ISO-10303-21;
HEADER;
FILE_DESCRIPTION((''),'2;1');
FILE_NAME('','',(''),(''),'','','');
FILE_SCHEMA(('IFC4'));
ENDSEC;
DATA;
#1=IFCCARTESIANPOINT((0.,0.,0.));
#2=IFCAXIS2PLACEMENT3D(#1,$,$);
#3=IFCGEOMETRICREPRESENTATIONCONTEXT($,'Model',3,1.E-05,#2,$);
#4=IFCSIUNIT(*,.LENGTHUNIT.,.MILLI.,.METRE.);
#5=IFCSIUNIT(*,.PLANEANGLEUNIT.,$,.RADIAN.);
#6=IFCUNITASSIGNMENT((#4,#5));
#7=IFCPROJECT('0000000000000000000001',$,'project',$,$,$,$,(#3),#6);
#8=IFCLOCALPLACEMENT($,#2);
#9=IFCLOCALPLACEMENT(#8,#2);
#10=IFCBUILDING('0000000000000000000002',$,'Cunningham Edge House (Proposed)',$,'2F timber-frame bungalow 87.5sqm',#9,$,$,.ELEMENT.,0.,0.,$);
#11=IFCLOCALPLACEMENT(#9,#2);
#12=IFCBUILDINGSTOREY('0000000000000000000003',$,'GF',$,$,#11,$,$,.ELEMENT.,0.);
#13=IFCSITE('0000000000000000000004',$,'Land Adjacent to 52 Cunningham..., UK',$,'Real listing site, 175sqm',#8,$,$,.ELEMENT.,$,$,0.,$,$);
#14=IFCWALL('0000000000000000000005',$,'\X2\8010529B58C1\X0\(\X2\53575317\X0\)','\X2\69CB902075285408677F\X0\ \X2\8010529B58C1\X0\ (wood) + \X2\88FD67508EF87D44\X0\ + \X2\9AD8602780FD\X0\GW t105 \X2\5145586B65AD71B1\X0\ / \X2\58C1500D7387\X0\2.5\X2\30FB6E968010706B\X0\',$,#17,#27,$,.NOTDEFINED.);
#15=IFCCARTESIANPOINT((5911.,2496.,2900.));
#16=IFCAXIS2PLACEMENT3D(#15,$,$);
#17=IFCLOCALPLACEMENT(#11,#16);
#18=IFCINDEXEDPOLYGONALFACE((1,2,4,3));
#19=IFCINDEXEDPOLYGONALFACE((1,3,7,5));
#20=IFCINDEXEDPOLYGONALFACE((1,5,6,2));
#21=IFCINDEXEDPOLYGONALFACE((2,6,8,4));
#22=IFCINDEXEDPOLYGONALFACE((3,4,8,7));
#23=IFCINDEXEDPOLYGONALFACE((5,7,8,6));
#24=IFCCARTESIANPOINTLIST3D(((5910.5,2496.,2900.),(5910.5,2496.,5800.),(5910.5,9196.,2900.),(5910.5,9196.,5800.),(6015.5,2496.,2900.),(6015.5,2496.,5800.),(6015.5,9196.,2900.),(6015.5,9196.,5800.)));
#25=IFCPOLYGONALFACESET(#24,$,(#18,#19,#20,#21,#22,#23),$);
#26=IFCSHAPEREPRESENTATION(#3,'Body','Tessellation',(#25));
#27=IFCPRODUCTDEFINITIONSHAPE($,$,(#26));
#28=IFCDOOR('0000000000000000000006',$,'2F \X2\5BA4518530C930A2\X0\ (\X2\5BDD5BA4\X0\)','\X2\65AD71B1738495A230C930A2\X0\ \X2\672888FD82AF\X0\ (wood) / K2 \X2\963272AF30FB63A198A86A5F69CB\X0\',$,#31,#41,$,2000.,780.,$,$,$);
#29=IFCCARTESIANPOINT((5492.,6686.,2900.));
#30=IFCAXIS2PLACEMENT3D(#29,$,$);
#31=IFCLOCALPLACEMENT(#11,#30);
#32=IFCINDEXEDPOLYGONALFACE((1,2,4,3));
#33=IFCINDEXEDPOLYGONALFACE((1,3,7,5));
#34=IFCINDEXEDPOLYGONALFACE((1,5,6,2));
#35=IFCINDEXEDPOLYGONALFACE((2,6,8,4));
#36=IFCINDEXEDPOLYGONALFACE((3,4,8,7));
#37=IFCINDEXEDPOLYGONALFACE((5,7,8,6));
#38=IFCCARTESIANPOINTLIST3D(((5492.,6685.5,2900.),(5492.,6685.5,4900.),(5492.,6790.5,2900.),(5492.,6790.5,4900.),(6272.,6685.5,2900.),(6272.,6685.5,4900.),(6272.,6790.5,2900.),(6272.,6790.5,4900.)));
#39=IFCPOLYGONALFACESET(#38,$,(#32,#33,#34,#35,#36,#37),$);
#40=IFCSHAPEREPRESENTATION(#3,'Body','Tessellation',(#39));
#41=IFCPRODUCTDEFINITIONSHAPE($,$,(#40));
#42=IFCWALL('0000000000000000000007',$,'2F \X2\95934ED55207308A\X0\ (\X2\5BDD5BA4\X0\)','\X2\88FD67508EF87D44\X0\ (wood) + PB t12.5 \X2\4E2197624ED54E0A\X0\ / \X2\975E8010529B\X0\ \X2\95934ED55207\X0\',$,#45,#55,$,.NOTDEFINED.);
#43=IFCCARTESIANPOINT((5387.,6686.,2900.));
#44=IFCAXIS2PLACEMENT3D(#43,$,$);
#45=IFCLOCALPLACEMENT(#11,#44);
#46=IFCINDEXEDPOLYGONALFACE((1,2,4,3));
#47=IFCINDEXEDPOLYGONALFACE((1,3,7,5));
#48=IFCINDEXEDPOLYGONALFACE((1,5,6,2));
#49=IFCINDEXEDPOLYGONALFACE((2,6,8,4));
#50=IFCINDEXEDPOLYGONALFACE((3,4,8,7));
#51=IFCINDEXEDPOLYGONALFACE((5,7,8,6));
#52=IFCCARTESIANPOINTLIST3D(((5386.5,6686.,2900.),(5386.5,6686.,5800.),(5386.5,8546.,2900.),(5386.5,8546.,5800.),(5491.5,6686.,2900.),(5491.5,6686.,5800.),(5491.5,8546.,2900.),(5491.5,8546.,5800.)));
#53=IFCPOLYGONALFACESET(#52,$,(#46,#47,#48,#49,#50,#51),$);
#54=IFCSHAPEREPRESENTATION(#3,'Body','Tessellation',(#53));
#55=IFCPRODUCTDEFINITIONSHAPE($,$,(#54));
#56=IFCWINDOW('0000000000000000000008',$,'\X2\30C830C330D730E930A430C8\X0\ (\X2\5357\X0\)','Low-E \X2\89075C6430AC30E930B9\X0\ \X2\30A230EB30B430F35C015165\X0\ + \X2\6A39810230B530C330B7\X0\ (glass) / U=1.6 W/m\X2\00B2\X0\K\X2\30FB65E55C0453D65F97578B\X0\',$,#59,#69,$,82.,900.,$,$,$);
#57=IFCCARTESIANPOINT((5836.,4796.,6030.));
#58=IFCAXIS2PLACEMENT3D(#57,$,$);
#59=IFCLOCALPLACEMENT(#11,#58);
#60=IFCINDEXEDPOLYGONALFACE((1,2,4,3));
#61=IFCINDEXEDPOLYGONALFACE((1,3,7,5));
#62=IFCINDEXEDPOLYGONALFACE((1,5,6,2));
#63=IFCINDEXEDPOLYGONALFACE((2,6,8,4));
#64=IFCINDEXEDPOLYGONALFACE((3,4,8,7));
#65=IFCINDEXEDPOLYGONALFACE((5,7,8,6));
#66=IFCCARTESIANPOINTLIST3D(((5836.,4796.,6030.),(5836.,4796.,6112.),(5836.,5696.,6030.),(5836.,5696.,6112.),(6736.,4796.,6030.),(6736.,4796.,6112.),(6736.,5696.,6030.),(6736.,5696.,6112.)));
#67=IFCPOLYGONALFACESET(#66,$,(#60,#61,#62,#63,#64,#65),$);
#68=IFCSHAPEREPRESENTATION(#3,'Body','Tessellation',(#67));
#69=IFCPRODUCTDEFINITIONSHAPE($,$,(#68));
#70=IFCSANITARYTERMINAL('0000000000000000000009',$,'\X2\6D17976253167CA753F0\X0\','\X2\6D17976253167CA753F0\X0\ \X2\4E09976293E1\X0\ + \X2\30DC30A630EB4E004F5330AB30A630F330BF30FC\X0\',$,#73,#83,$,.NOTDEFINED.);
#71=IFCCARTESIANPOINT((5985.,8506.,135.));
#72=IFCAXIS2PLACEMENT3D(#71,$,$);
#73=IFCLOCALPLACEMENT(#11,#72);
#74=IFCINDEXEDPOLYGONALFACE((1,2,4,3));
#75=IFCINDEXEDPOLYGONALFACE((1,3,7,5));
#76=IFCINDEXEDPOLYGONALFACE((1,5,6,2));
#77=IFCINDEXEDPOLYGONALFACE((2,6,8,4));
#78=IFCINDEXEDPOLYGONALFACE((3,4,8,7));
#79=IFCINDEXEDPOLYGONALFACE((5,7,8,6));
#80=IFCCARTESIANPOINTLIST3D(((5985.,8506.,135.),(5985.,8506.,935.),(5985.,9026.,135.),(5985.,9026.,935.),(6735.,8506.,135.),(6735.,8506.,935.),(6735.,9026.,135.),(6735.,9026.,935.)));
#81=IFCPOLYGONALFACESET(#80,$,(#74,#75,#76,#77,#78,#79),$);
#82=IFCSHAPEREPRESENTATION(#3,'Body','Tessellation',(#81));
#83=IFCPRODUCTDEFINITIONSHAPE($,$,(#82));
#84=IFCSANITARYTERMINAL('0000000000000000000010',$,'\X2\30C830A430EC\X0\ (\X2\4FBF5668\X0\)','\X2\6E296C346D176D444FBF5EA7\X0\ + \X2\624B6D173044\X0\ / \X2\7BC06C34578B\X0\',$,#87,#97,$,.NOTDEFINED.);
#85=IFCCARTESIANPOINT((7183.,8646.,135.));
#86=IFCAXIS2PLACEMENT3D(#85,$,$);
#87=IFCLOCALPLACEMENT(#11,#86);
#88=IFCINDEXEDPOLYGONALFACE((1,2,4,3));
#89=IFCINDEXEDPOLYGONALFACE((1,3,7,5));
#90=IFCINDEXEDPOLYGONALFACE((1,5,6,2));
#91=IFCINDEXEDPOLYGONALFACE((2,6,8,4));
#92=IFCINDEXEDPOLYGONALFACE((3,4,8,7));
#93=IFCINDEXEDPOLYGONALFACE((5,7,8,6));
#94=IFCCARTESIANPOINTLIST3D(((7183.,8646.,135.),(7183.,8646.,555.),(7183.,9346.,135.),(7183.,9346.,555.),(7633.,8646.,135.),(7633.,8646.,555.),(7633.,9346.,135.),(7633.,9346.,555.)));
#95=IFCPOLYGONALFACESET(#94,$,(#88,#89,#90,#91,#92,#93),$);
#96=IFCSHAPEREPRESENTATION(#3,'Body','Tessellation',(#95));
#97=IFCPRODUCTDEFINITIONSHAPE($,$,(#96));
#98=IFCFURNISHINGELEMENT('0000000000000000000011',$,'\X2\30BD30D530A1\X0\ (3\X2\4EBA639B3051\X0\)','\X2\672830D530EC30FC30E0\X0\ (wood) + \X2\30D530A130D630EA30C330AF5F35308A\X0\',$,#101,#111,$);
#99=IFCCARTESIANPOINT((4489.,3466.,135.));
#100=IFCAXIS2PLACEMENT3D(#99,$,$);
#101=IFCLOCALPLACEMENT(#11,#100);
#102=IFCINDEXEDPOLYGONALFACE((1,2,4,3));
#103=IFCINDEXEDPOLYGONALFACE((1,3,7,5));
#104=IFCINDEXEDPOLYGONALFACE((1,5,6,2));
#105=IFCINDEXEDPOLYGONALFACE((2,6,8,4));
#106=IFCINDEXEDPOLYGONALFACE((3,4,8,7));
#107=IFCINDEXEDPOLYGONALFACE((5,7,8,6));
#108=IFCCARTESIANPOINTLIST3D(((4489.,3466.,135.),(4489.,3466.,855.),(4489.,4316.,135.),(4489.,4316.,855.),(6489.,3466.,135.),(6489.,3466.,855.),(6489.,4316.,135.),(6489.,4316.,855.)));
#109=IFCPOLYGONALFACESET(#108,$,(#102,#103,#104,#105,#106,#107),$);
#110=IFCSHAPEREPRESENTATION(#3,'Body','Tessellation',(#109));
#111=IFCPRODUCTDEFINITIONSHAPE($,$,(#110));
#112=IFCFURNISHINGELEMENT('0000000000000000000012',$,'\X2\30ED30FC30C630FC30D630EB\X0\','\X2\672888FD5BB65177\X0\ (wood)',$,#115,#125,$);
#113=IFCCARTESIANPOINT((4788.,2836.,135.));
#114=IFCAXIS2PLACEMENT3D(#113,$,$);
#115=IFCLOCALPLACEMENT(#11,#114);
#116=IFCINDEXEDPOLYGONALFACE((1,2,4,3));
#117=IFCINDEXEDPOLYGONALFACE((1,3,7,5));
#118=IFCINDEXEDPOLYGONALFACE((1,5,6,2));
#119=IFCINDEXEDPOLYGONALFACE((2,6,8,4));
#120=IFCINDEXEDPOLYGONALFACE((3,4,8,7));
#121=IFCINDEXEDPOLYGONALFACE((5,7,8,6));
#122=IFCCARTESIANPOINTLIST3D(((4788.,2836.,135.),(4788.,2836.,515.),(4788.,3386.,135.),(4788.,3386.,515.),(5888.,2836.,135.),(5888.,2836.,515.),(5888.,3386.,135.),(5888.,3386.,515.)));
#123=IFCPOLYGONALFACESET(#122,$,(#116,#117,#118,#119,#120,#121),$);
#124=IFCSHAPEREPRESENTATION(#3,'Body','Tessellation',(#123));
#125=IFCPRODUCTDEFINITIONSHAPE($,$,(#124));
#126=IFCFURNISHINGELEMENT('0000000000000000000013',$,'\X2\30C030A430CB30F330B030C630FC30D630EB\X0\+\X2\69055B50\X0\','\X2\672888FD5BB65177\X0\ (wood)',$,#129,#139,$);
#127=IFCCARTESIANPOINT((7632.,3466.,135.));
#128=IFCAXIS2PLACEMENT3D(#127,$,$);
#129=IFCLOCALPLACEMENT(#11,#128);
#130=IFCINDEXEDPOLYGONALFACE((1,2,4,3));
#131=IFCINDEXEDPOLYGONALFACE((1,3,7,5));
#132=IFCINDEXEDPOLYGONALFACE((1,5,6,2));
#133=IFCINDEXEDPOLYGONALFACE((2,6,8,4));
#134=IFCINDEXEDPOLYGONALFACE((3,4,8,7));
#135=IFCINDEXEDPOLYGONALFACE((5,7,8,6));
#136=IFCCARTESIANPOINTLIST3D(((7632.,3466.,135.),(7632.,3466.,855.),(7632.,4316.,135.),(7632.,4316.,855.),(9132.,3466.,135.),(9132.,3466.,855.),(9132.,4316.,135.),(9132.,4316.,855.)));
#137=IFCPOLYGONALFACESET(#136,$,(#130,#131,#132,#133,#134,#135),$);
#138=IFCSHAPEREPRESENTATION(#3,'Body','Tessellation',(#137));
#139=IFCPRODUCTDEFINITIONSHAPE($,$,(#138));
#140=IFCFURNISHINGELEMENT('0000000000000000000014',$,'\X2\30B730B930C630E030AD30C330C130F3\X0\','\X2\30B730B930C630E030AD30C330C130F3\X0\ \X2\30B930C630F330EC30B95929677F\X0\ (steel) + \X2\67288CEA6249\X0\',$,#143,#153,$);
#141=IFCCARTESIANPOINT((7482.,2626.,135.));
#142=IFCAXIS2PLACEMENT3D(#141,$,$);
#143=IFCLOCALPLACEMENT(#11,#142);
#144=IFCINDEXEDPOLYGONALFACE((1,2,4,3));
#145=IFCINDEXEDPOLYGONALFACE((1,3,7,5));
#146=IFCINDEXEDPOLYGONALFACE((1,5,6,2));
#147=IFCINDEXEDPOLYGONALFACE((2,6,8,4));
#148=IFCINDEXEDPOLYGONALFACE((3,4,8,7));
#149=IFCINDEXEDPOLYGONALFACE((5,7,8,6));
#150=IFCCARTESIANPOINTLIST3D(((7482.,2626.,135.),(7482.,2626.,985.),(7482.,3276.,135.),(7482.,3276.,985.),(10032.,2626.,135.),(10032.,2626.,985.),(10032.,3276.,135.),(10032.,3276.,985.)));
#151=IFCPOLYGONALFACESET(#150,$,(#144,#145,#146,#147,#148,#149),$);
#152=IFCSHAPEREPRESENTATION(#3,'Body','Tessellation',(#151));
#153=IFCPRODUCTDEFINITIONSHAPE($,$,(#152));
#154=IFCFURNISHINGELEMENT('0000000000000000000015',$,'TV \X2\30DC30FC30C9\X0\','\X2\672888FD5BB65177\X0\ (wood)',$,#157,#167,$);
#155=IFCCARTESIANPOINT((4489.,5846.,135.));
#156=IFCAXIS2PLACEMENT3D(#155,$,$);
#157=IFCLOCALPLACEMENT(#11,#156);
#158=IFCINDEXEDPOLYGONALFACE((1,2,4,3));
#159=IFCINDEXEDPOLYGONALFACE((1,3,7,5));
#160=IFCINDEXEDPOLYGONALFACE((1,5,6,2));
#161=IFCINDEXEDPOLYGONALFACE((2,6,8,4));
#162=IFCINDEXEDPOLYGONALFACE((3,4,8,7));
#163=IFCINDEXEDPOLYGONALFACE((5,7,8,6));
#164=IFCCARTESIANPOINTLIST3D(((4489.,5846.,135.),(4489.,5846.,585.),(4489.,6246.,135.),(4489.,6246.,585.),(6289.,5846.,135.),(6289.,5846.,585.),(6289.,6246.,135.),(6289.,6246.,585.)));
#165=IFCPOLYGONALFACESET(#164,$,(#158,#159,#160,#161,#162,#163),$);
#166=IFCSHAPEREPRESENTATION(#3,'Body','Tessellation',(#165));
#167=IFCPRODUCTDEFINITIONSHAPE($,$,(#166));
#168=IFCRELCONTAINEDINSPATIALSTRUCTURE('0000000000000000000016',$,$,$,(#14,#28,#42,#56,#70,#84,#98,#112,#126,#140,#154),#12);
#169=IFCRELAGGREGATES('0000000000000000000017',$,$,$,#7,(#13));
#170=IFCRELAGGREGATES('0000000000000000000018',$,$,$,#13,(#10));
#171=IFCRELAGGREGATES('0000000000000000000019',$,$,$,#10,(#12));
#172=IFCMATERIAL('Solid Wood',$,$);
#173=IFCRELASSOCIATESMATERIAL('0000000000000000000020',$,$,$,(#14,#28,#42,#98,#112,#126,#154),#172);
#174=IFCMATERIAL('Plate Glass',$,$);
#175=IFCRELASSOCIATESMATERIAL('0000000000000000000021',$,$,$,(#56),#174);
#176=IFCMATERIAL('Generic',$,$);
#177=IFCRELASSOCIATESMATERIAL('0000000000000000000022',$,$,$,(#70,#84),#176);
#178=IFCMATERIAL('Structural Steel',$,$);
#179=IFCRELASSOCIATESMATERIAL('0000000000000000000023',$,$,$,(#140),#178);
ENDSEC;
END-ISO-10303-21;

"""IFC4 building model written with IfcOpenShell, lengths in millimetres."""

from ifc_helpers import new_model, si_unit, frame, frame_2d, origin, place, context, project, spatial, rectangle, extrude, material, element, fill, save


model = new_model("IFC4")

# Units and contexts
model_context = context("Model", 3, precision=1e-05, world=origin())
ifc_project = project(units=[si_unit("LENGTHUNIT", "METRE", prefix="MILLI"), si_unit("PLANEANGLEUNIT", "RADIAN")], contexts=[model_context])

# Site, building, storey
site_placement = place(None, origin())
site = spatial("IfcSite", under=ifc_project, at=site_placement, Name="Land Adjacent to 52 Cunningham..., UK", ObjectType="Real listing site, 175sqm", CompositionType="ELEMENT", RefElevation=0.0)
building_placement = place(site_placement, origin())
building = spatial("IfcBuilding", under=site, at=building_placement, Name="Cunningham Edge House (Proposed)", ObjectType="2F timber-frame bungalow 87.5sqm", CompositionType="ELEMENT", ElevationOfRefHeight=0.0, ElevationOfTerrain=0.0)
storey_placement = place(building_placement, origin())
storey = spatial("IfcBuildingStorey", under=building, at=storey_placement, Name="GF", CompositionType="ELEMENT", Elevation=0.0)

# Shared definitions
ifc_material_1 = material(Name="Solid Wood")

# Wall, opening, door
wall_1_placement = place(storey_placement, frame((5911.0, 2496.0, 2900.0)))
wall_1 = element("IfcWall", 1, at=wall_1_placement, inside=storey, material=ifc_material_1, Name="耐力壁(南北)", Description="構造用合板 耐力壁 (wood) + 製材軸組 + 高性能GW t105 充填断熱 / 壁倍率2.5・準耐火", PredefinedType="NOTDEFINED", context=model_context, shape_type="SweptSolid", body=[
    extrude(rectangle(XDim=105.0, YDim=6700.0, at=frame_2d((52.0, 3350.0))), frame((5911.0, 2496.0, 2900.0)), (0.0, 0.0, 1.0), 2900.0),
])
opening_1_placement = place(storey_placement, frame((5492.0, 6686.0, 2900.0)))
opening_1 = element("IfcOpeningElement", 2, at=opening_1_placement, cuts=wall_1, PredefinedType="NOTDEFINED", context=model_context, shape_type="SweptSolid", body=[
    extrude(rectangle(XDim=780.0, YDim=105.0, at=frame_2d((390.0, 52.0))), frame((5492.0, 6686.0, 2900.0)), (0.0, 0.0, 1.0), 2000.0),
])
door_1_placement = place(storey_placement, frame((5492.0, 6686.0, 2900.0)))
door_1 = element("IfcDoor", 3, at=door_1_placement, inside=storey, material=ifc_material_1, Name="2F 室内ドア (寝室)", Description="断熱玄関ドア 木製芯 (wood) / K2 防犯・採風機構", OverallHeight=2000.0, OverallWidth=780.0, context=model_context, shape_type="SweptSolid", body=[
    extrude(rectangle(XDim=780.0, YDim=105.0, at=frame_2d((390.0, 52.0))), frame((5492.0, 6686.0, 2900.0)), (0.0, 0.0, 1.0), 2000.0),
])
fill(opening_1, door_1)

# Wall
wall_2_placement = place(storey_placement, frame((5387.0, 6686.0, 2900.0)))
element("IfcWall", 4, at=wall_2_placement, inside=storey, material=ifc_material_1, Name="2F 間仕切り (寝室)", Description="製材軸組 (wood) + PB t12.5 両面仕上 / 非耐力 間仕切", PredefinedType="NOTDEFINED", context=model_context, shape_type="SweptSolid", body=[
    extrude(rectangle(XDim=105.0, YDim=1860.0, at=frame_2d((52.0, 930.0))), frame((5387.0, 6686.0, 2900.0)), (0.0, 0.0, 1.0), 2900.0),
])

# Window
ifc_material_2 = material(Name="Plate Glass")
window_placement = place(storey_placement, frame((5836.0, 4796.0, 6030.0)))
element("IfcWindow", 5, at=window_placement, inside=storey, material=ifc_material_2, Name="トップライト (南)", Description="Low-E 複層ガラス アルゴン封入 + 樹脂サッシ (glass) / U=1.6 W/m²K・日射取得型", OverallHeight=82.0, OverallWidth=900.0, context=model_context, shape_type="SweptSolid", body=[
    extrude(rectangle(XDim=900.0, YDim=900.0, at=frame_2d((450.0, 450.0))), frame((5836.0, 4796.0, 6030.0)), (0.0, 0.0, 1.0), 82.0),
])

# Sanitary terminals
ifc_material_3 = material(Name="Generic")
sanitary_terminal_1_placement = place(storey_placement, frame((5985.0, 8506.0, 135.0)))
element("IfcSanitaryTerminal", 6, at=sanitary_terminal_1_placement, inside=storey, material=ifc_material_3, Name="洗面化粧台", Description="洗面化粧台 三面鏡 + ボウル一体カウンター", PredefinedType="NOTDEFINED", context=model_context, shape_type="SweptSolid", body=[
    extrude(rectangle(XDim=750.0, YDim=520.0, at=frame_2d((375.0, 260.0))), frame((5985.0, 8506.0, 135.0)), (0.0, 0.0, 1.0), 800.0),
])
sanitary_terminal_2_placement = place(storey_placement, frame((7183.0, 8646.0, 135.0)))
element("IfcSanitaryTerminal", 7, at=sanitary_terminal_2_placement, inside=storey, material=ifc_material_3, Name="トイレ (便器)", Description="温水洗浄便座 + 手洗い / 節水型", PredefinedType="NOTDEFINED", context=model_context, shape_type="SweptSolid", body=[
    extrude(rectangle(XDim=450.0, YDim=700.0, at=frame_2d((225.0, 350.0))), frame((7183.0, 8646.0, 135.0)), (0.0, 0.0, 1.0), 420.0),
])

# Furnishing elements
furnishing_1_placement = place(storey_placement, frame((4489.0, 3466.0, 135.0)))
element("IfcFurnishingElement", 8, at=furnishing_1_placement, inside=storey, material=ifc_material_1, Name="ソファ (3人掛け)", Description="木フレーム (wood) + ファブリック張り", context=model_context, shape_type="SweptSolid", body=[
    extrude(rectangle(XDim=2000.0, YDim=850.0, at=frame_2d((1000.0, 425.0))), frame((4489.0, 3466.0, 135.0)), (0.0, 0.0, 1.0), 720.0),
])
furnishing_2_placement = place(storey_placement, frame((4788.0, 2836.0, 135.0)))
element("IfcFurnishingElement", 9, at=furnishing_2_placement, inside=storey, material=ifc_material_1, Name="ローテーブル", Description="木製家具 (wood)", context=model_context, shape_type="SweptSolid", body=[
    extrude(rectangle(XDim=1100.0, YDim=550.0, at=frame_2d((550.0, 275.0))), frame((4788.0, 2836.0, 135.0)), (0.0, 0.0, 1.0), 380.0),
])
furnishing_3_placement = place(storey_placement, frame((7632.0, 3466.0, 135.0)))
element("IfcFurnishingElement", 10, at=furnishing_3_placement, inside=storey, material=ifc_material_1, Name="ダイニングテーブル+椅子", Description="木製家具 (wood)", context=model_context, shape_type="SweptSolid", body=[
    extrude(rectangle(XDim=1500.0, YDim=850.0, at=frame_2d((750.0, 425.0))), frame((7632.0, 3466.0, 135.0)), (0.0, 0.0, 1.0), 720.0),
])
ifc_material_4 = material(Name="Structural Steel")
furnishing_4_placement = place(storey_placement, frame((7482.0, 2626.0, 135.0)))
element("IfcFurnishingElement", 11, at=furnishing_4_placement, inside=storey, material=ifc_material_4, Name="システムキッチン", Description="システムキッチン ステンレス天板 (steel) + 木質扉", context=model_context, shape_type="SweptSolid", body=[
    extrude(rectangle(XDim=2550.0, YDim=650.0, at=frame_2d((1275.0, 325.0))), frame((7482.0, 2626.0, 135.0)), (0.0, 0.0, 1.0), 850.0),
])
furnishing_5_placement = place(storey_placement, frame((4489.0, 5846.0, 135.0)))
element("IfcFurnishingElement", 12, at=furnishing_5_placement, inside=storey, material=ifc_material_1, Name="TV ボード", Description="木製家具 (wood)", context=model_context, shape_type="SweptSolid", body=[
    extrude(rectangle(XDim=1800.0, YDim=400.0, at=frame_2d((900.0, 200.0))), frame((4489.0, 5846.0, 135.0)), (0.0, 0.0, 1.0), 450.0),
])

save(model, "model.ifc")
